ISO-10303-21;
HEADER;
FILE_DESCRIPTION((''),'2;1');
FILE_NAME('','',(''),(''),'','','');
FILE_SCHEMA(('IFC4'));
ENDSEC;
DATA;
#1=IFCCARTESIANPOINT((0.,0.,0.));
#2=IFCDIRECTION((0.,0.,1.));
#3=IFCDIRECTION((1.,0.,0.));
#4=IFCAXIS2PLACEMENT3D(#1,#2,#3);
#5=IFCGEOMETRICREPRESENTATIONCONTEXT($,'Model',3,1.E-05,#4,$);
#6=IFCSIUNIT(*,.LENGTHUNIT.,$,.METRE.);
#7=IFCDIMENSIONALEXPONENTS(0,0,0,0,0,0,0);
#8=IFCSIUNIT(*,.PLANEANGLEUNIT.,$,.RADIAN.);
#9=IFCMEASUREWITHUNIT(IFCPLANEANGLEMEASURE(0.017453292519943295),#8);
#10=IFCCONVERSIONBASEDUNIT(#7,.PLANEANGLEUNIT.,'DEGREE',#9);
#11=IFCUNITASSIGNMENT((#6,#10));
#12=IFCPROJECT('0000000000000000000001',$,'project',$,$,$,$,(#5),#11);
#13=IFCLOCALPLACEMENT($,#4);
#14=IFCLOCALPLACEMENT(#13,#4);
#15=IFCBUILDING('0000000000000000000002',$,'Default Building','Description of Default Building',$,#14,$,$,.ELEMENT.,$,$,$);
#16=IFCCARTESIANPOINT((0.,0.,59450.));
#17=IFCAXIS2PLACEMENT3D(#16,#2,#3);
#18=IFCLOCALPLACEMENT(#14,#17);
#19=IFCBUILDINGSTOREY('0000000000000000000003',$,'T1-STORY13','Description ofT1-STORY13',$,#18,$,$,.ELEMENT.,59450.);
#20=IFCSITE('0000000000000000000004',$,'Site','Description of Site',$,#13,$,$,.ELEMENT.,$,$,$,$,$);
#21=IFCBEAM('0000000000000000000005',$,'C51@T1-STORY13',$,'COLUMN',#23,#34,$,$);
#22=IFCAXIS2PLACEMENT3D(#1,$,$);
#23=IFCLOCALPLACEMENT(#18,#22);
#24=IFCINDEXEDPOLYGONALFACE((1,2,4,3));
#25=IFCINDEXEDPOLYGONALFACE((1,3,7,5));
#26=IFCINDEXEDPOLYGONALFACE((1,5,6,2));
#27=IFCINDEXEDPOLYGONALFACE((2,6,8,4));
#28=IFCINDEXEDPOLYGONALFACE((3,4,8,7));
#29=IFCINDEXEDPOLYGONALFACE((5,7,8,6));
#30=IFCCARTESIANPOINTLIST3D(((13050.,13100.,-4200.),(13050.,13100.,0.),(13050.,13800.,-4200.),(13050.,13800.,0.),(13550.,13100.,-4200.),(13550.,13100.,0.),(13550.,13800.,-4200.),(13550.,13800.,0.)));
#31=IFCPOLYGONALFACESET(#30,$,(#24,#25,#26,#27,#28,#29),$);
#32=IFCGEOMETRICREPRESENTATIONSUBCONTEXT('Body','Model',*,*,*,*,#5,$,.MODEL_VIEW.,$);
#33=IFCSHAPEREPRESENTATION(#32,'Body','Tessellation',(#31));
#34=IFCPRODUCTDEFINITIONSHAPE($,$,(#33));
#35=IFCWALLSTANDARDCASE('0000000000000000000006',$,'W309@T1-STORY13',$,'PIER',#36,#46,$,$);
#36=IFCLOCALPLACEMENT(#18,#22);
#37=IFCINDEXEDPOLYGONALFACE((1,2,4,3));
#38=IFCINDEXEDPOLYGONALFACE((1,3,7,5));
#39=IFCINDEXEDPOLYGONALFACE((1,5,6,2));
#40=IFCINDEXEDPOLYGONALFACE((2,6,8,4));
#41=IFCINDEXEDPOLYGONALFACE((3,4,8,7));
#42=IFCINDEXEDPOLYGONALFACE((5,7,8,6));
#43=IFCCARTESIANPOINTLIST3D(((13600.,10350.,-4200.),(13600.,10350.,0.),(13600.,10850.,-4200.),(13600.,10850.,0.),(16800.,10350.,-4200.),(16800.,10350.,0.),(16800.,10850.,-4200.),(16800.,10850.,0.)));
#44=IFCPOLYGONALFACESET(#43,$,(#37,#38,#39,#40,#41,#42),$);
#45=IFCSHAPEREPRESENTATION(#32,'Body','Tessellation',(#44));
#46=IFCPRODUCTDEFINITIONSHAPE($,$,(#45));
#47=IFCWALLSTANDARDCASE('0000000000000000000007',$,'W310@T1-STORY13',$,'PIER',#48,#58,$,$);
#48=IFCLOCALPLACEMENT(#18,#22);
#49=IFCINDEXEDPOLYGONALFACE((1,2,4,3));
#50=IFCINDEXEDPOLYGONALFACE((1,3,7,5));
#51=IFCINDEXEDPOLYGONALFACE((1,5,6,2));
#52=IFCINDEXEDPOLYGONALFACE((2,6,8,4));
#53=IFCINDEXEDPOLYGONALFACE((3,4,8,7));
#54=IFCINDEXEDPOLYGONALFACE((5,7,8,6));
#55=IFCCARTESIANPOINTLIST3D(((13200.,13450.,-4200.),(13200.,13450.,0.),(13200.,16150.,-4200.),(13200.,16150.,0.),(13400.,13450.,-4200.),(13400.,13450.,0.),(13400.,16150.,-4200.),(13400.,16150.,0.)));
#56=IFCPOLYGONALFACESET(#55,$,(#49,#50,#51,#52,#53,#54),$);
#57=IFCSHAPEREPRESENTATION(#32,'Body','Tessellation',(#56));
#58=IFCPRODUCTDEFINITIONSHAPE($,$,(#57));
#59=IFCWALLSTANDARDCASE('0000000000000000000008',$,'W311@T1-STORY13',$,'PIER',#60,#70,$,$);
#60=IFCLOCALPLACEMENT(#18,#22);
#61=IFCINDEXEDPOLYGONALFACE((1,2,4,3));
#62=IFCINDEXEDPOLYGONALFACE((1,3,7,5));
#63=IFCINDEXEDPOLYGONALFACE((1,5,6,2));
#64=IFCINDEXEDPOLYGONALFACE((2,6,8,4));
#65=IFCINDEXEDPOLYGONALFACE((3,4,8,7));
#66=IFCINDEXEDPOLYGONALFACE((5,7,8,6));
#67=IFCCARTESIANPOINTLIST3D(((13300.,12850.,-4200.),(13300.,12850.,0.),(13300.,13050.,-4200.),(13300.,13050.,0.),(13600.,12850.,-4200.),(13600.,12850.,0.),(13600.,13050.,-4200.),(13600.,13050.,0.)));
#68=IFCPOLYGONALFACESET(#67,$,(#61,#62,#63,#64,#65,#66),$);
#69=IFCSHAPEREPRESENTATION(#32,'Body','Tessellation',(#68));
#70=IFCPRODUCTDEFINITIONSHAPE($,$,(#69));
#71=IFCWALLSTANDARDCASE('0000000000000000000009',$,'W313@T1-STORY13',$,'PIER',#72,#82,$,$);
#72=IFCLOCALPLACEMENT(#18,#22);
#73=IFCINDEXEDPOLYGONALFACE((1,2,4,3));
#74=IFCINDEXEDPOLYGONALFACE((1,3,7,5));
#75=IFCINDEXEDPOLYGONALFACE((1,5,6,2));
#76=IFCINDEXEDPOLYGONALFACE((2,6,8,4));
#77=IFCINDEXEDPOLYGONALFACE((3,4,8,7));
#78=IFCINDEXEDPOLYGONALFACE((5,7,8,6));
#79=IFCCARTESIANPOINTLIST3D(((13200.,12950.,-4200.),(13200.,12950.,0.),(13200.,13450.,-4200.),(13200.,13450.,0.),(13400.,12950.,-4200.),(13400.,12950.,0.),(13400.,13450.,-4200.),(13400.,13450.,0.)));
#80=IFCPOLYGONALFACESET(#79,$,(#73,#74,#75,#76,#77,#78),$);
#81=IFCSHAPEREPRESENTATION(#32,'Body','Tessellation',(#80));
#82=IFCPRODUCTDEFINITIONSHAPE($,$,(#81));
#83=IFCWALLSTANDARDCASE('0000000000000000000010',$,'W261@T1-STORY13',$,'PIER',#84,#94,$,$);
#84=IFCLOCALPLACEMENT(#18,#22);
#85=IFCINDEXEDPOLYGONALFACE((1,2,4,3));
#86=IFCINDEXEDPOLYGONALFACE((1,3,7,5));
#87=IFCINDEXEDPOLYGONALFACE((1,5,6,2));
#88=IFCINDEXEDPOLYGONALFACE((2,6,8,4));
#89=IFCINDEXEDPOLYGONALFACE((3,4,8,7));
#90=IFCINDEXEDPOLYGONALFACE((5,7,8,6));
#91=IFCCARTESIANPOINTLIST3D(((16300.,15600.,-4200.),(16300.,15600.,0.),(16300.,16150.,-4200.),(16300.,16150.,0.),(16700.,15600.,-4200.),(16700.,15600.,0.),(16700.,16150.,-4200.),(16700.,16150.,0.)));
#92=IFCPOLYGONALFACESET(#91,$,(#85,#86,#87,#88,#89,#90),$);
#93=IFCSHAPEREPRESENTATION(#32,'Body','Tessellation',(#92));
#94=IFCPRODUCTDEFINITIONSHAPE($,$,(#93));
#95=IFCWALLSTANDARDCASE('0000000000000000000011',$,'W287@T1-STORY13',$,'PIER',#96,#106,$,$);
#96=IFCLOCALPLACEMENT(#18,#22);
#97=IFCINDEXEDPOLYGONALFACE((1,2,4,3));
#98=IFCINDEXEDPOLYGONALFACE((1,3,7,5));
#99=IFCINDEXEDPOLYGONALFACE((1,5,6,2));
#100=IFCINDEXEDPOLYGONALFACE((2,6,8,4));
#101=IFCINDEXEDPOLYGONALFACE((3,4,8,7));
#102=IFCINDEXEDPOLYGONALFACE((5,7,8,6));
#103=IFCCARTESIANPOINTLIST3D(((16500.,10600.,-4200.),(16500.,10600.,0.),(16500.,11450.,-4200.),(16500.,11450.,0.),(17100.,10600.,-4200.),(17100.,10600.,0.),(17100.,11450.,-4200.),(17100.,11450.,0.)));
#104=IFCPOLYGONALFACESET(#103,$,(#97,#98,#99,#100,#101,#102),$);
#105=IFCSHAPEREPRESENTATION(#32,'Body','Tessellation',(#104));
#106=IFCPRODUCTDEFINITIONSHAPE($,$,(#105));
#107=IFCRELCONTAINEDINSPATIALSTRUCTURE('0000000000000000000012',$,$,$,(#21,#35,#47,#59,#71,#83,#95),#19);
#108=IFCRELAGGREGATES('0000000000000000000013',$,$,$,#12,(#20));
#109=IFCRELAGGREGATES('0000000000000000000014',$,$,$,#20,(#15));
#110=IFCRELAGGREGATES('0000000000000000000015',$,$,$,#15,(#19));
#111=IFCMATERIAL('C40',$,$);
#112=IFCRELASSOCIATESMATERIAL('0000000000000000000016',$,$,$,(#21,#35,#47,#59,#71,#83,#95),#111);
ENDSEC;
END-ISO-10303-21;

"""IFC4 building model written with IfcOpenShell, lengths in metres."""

from ifc_helpers import new_model, entity, si_unit, converted_unit, frame, origin_with_axes, place, context, subcontext, project, spatial, indexed_curve, rectangle, outline, extrude, material, element, save


model = new_model("IFC4")

# Units and contexts
model_context = context("Model", 3, precision=1e-05, world=origin_with_axes())
body_context = subcontext(model_context, "Body", "Model", "MODEL_VIEW")
ifc_project = project(units=[si_unit("LENGTHUNIT", "METRE"), converted_unit("PLANEANGLEUNIT", "DEGREE", entity("IfcPlaneAngleMeasure", 0.017453292519943295), si_unit("PLANEANGLEUNIT", "RADIAN"), dimensions=[0, 0, 0, 0, 0, 0, 0])], contexts=[model_context])

# Site, building, storey
site_placement = place(None, origin_with_axes())
site = spatial("IfcSite", under=ifc_project, at=site_placement, Name="Site", Description="Description of Site", CompositionType="ELEMENT")
building_placement = place(site_placement, origin_with_axes())
building = spatial("IfcBuilding", under=site, at=building_placement, Name="Default Building", Description="Description of Default Building", CompositionType="ELEMENT")
storey_placement = place(building_placement, frame((0.0, 0.0, 59450.0), z_axis=(0.0, 0.0, 1.0), x_axis=(1.0, 0.0, 0.0)))
storey = spatial("IfcBuildingStorey", under=building, at=storey_placement, Name="T1-STORY13", Description="Description ofT1-STORY13", CompositionType="ELEMENT", Elevation=59450.0)

# Beam
ifc_material_1 = material(Name="C40")
beam_1_placement = place(storey_placement, frame((13300.0, 13450.0, -4200.0), z_axis=(0.0, 0.0, 1.0), x_axis=(-1.0, 0.0, 0.0)))
element("IfcBeam", 1, at=beam_1_placement, inside=storey, material=ifc_material_1, Name="C51@T1-STORY13", ObjectType="COLUMN", context=body_context, shape_type="SweptSolid", body=[
    extrude(rectangle(XDim=500.0, YDim=700.0), origin_with_axes(), (0.0, 0.0, 1.0), 4200.0),
])

# Walls
wall_1_placement = place(storey_placement, frame((13600.0, 10600.0, -4200.0), z_axis=(0.0, 0.0, 1.0), x_axis=(1.0, 0.0, 0.0)))
element("IfcWallStandardCase", 2, at=wall_1_placement, inside=storey, material=ifc_material_1, Name="W309@T1-STORY13", ObjectType="PIER", context=body_context, shape_type="SweptSolid", body=[
    extrude(outline(indexed_curve([(0.0, -250.0), (0.0, 250.0), (3200.0, 250.0), (3200.0, -250.0), (0.0, -250.0)], self_intersect=False)), origin_with_axes(), (0.0, 0.0, 1.0), 4200.0),
])
wall_2_placement = place(storey_placement, frame((13300.0, 13450.0, -4200.0), z_axis=(0.0, 0.0, 1.0), x_axis=(0.0, 1.0, 0.0)))
element("IfcWallStandardCase", 3, at=wall_2_placement, inside=storey, material=ifc_material_1, Name="W310@T1-STORY13", ObjectType="PIER", context=body_context, shape_type="SweptSolid", body=[
    extrude(outline(indexed_curve([(0.0, -100.0), (0.0, 100.0), (2700.0, 100.0), (2700.0, -100.0), (0.0, -100.0)], self_intersect=False)), origin_with_axes(), (0.0, 0.0, 1.0), 4200.0),
])
wall_3_placement = place(storey_placement, frame((13300.0, 12950.0, -4200.0), z_axis=(0.0, 0.0, 1.0), x_axis=(1.0, 0.0, 0.0)))
element("IfcWallStandardCase", 4, at=wall_3_placement, inside=storey, material=ifc_material_1, Name="W311@T1-STORY13", ObjectType="PIER", context=body_context, shape_type="SweptSolid", body=[
    extrude(outline(indexed_curve([(0.0, -100.0), (0.0, 100.0), (300.0, 100.0), (300.0, -100.0), (0.0, -100.0)], self_intersect=False)), origin_with_axes(), (0.0, 0.0, 1.0), 4200.0),
])
wall_4_placement = place(storey_placement, frame((13300.0, 12950.0, -4200.0), z_axis=(0.0, 0.0, 1.0), x_axis=(0.0, 1.0, 0.0)))
element("IfcWallStandardCase", 5, at=wall_4_placement, inside=storey, material=ifc_material_1, Name="W313@T1-STORY13", ObjectType="PIER", context=body_context, shape_type="SweptSolid", body=[
    extrude(outline(indexed_curve([(0.0, -100.0), (0.0, 100.0), (500.0, 100.0), (500.0, -100.0), (0.0, -100.0)], self_intersect=False)), origin_with_axes(), (0.0, 0.0, 1.0), 4200.0),
])
wall_5_placement = place(storey_placement, frame((16500.0, 15600.0, -4200.0), z_axis=(0.0, 0.0, 1.0), x_axis=(0.0, 1.0, 0.0)))
element("IfcWallStandardCase", 6, at=wall_5_placement, inside=storey, material=ifc_material_1, Name="W261@T1-STORY13", ObjectType="PIER", context=body_context, shape_type="SweptSolid", body=[
    extrude(outline(indexed_curve([(0.0, -200.0), (0.0, 200.0), (550.0, 200.0), (550.0, -200.0), (0.0, -200.0)], self_intersect=False)), origin_with_axes(), (0.0, 0.0, 1.0), 4200.0),
])
wall_6_placement = place(storey_placement, frame((16800.0, 10600.0, -4200.0), z_axis=(0.0, 0.0, 1.0), x_axis=(0.0, 1.0, 0.0)))
element("IfcWallStandardCase", 7, at=wall_6_placement, inside=storey, material=ifc_material_1, Name="W287@T1-STORY13", ObjectType="PIER", context=body_context, shape_type="SweptSolid", body=[
    extrude(outline(indexed_curve([(0.0, -300.0), (0.0, 300.0), (850.0, 300.0), (850.0, -300.0), (0.0, -300.0)], self_intersect=False)), origin_with_axes(), (0.0, 0.0, 1.0), 4200.0),
])

save(model, "model.ifc")
